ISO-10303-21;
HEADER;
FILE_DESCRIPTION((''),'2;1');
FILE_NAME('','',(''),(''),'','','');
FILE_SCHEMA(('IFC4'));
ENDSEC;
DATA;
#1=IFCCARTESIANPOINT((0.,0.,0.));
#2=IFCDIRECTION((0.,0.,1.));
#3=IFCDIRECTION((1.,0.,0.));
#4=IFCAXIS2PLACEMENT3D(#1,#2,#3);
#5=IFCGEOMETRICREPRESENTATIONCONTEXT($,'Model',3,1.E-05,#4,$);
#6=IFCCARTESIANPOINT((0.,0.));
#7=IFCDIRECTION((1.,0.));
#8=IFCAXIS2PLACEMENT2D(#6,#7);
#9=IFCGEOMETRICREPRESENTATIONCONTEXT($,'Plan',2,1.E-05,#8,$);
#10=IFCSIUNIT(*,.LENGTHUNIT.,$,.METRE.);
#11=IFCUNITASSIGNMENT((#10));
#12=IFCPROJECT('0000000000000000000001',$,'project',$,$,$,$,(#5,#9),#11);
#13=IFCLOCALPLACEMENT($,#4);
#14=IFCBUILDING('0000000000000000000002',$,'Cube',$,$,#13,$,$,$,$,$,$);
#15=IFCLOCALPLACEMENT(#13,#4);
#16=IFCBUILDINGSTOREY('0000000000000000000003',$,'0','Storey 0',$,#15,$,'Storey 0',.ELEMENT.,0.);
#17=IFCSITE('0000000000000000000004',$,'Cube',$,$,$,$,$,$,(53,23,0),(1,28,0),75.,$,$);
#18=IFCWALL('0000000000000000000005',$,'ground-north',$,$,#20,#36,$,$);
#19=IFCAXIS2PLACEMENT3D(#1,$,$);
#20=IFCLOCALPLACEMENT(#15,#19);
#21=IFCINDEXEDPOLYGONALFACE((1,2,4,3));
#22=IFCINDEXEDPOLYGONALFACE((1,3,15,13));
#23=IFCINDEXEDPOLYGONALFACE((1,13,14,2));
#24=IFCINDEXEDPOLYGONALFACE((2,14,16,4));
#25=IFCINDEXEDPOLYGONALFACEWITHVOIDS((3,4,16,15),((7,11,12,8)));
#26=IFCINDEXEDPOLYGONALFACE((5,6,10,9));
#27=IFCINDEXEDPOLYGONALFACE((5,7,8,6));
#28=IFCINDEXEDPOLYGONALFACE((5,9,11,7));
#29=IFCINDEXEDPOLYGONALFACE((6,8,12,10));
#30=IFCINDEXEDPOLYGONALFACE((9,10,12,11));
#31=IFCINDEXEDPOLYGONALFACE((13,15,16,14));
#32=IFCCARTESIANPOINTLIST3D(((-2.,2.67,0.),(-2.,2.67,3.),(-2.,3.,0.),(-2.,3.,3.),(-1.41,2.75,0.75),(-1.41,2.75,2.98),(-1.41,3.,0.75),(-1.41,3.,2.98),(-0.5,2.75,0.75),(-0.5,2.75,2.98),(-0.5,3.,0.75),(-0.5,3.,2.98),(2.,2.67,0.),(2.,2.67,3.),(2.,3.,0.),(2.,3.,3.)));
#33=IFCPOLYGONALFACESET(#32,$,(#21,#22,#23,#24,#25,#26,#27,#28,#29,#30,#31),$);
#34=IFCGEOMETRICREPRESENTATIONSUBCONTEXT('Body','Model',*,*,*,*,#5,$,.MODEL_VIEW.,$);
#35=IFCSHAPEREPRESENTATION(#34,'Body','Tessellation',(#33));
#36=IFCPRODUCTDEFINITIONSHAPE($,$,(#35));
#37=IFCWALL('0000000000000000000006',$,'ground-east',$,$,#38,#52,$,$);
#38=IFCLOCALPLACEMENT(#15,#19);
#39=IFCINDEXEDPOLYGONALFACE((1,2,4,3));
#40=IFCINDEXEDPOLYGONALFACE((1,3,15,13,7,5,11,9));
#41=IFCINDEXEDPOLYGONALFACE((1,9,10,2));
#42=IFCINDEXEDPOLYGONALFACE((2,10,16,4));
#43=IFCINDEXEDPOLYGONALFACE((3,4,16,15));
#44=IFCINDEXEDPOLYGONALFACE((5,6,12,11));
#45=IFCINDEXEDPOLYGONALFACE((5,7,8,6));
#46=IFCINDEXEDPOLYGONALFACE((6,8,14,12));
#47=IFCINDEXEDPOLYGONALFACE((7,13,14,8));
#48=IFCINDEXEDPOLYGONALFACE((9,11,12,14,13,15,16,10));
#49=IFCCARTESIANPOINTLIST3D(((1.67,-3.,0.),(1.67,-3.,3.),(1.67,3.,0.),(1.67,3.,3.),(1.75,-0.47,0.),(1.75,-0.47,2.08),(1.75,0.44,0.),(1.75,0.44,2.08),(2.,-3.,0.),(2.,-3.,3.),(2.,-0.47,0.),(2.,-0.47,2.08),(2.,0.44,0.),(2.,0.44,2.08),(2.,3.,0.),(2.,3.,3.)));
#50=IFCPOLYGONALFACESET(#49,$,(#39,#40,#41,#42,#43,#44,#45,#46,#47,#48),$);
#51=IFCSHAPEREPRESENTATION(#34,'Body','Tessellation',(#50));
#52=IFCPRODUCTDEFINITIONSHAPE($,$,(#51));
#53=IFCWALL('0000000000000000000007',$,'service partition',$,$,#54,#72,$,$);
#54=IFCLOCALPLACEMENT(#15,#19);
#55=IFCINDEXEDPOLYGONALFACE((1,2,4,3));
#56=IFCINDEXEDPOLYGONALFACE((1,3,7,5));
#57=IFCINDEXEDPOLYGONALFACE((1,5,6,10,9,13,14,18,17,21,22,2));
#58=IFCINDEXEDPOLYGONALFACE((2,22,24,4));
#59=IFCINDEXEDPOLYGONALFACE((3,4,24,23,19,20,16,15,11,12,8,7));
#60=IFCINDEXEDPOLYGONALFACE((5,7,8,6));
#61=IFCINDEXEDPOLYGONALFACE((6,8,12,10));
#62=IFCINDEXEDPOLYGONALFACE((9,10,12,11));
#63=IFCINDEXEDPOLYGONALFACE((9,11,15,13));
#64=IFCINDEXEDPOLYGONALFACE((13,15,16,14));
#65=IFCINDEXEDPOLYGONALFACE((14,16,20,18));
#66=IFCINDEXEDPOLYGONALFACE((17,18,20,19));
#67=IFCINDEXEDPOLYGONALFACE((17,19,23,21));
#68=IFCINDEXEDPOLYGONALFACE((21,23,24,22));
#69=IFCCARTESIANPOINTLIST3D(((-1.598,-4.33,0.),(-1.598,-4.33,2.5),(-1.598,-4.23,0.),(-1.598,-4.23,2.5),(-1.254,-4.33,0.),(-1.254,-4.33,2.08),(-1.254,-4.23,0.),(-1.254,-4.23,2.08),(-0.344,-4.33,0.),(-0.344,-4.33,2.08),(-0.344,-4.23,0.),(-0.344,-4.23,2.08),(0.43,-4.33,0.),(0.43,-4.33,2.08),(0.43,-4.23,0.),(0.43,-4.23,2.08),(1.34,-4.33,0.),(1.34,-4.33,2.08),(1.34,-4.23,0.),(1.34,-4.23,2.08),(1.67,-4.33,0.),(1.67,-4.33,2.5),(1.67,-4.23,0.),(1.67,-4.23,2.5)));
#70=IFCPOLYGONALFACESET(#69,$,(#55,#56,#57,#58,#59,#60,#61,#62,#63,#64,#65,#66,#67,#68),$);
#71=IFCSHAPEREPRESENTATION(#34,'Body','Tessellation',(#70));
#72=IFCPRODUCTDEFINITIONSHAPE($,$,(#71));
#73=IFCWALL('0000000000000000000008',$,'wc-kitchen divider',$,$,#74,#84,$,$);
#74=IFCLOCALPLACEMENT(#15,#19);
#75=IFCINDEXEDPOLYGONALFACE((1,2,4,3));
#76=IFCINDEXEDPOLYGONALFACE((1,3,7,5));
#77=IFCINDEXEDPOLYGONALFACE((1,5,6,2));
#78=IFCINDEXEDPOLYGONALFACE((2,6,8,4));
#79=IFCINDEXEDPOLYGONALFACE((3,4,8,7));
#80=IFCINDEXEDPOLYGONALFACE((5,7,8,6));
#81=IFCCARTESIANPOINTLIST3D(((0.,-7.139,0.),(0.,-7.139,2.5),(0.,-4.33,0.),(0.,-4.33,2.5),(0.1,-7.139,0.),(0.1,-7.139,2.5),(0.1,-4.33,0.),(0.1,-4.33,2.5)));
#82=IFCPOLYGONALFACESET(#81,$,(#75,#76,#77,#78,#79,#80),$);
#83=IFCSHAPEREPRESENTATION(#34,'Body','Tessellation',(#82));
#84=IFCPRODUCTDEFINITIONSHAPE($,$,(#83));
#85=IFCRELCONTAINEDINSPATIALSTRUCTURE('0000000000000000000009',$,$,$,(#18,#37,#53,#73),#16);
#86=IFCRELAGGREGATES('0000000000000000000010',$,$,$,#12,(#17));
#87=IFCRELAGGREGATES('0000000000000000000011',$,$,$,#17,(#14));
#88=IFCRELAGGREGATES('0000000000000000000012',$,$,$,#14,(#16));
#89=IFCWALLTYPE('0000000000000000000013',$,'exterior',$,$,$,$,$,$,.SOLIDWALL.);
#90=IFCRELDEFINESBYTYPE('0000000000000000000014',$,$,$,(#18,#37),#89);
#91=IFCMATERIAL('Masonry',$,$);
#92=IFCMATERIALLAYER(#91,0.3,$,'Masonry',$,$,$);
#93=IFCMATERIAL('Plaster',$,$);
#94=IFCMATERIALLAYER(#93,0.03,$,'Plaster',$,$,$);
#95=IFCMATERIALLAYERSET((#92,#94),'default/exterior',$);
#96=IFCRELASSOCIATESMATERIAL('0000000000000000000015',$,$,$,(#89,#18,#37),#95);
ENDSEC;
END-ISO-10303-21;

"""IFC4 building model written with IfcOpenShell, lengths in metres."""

from ifc_helpers import new_model, si_unit, frame, origin_with_axes, origin_2d_with_axis, place, context, subcontext, project, spatial, line, indexed_curve, outline, extrude, material, layer, layer_set, layer_usage, type_object, element, save


model = new_model("IFC4")

# Units and contexts
model_context = context("Model", 3, precision=1e-05, world=origin_with_axes())
plan_context = context("Plan", 2, precision=1e-05, world=origin_2d_with_axis())
body_context = subcontext(model_context, "Body", "Model", "MODEL_VIEW")
ifc_project = project(units=[si_unit("LENGTHUNIT", "METRE")], contexts=[model_context, plan_context])

# Site, building, storey
site = spatial("IfcSite", under=ifc_project, Name="Cube", RefLatitude=(53, 23, 0), RefLongitude=(1, 28, 0), RefElevation=75.0)
building_placement = place(None, origin_with_axes())
building = spatial("IfcBuilding", under=site, at=building_placement, Name="Cube")
storey_placement = place(building_placement, origin_with_axes())
storey = spatial("IfcBuildingStorey", under=building, at=storey_placement, Name="0", Description="Storey 0", LongName="Storey 0", CompositionType="ELEMENT", Elevation=0.0)

# Shared definitions
ifc_material_1 = material(Name="Masonry")
ifc_layer_1 = layer(ifc_material_1, 0.3, Name="Masonry")
ifc_material_2 = material(Name="Plaster")
ifc_layer_2 = layer(ifc_material_2, 0.03, Name="Plaster")
ifc_layer_set_1 = layer_set([ifc_layer_1, ifc_layer_2], Name="default/exterior")
wall_type = type_object("IfcWallType", Name="exterior", PredefinedType="SOLIDWALL", material=ifc_layer_set_1)

# Wall, opening
ifc_layer_usage_1 = layer_usage(ifc_layer_set_1, "AXIS2", "POSITIVE", 0.0)
wall_1_placement = place(storey_placement, frame((2.0, 3.0, 0.0), z_axis=(0.0, 0.0, 1.0), x_axis=(-1.0, 0.0, 0.0)))
wall_1 = element("IfcWall", 1, at=wall_1_placement, inside=storey, type_object=wall_type, material=ifc_layer_usage_1, Name="ground-north", context=body_context, shape_type="SweptSolid", body=[
    extrude(outline(indexed_curve([(0.0, 0.0), (4.0, 0.0), (4.0, 0.33), (0.0, 0.33)], segments=[line(1, 2, 3, 4, 1)])), origin_with_axes(), (0.0, 0.0, 1.0), 3.0),
])
opening_1_placement = place(wall_1_placement, frame((2.5, -0.25, 0.75), z_axis=(0.0, 0.0, 1.0), x_axis=(1.0, 0.0, 0.0)))
element("IfcOpeningElement", 2, at=opening_1_placement, cuts=wall_1, PredefinedType="OPENING", context=body_context, shape_type="SweptSolid", body=[
    extrude(outline(indexed_curve([(0.0, 0.0), (0.0, 0.5), (0.91, 0.5), (0.91, 0.0), (0.0, 0.0)], self_intersect=False)), origin_with_axes(), (0.0, 0.0, 1.0), 2.23),
])

# Wall, opening
ifc_layer_usage_2 = layer_usage(ifc_layer_set_1, "AXIS2", "POSITIVE", 0.0)
wall_2_placement = place(storey_placement, frame((2.0, -3.0, 0.0), z_axis=(0.0, 0.0, 1.0), x_axis=(0.0, 1.0, 0.0)))
wall_2 = element("IfcWall", 3, at=wall_2_placement, inside=storey, type_object=wall_type, material=ifc_layer_usage_2, Name="ground-east", context=body_context, shape_type="SweptSolid", body=[
    extrude(outline(indexed_curve([(0.0, 0.0), (6.0, 0.0), (6.0, 0.33), (0.0, 0.33)], segments=[line(1, 2, 3, 4, 1)])), origin_with_axes(), (0.0, 0.0, 1.0), 3.0),
])
opening_2_placement = place(wall_2_placement, frame((2.53, -0.25, 0.0), z_axis=(0.0, 0.0, 1.0), x_axis=(1.0, 0.0, 0.0)))
element("IfcOpeningElement", 4, at=opening_2_placement, cuts=wall_2, PredefinedType="OPENING", context=body_context, shape_type="SweptSolid", body=[
    extrude(outline(indexed_curve([(0.0, 0.0), (0.0, 0.5), (0.91, 0.5), (0.91, 0.0), (0.0, 0.0)], self_intersect=False)), origin_with_axes(), (0.0, 0.0, 1.0), 2.08),
])

# Wall, openings
wall_3_placement = place(storey_placement, frame((-1.598, -4.33, 0.0), z_axis=(0.0, 0.0, 1.0), x_axis=(1.0, 0.0, 0.0)))
wall_3 = element("IfcWall", 5, at=wall_3_placement, inside=storey, Name="service partition", context=body_context, shape_type="SweptSolid", body=[
    extrude(outline(indexed_curve([(0.0, 0.0), (0.0, 0.1), (3.268, 0.1), (3.268, 0.0), (0.0, 0.0)], self_intersect=False)), origin_with_axes(), (0.0, 0.0, 1.0), 2.5),
])
opening_3_placement = place(wall_3_placement, frame((0.344, -0.05, 0.0), z_axis=(0.0, 0.0, 1.0), x_axis=(1.0, 0.0, 0.0)))
element("IfcOpeningElement", 6, at=opening_3_placement, cuts=wall_3, context=body_context, shape_type="SweptSolid", body=[
    extrude(outline(indexed_curve([(0.0, 0.0), (0.0, 0.3), (0.91, 0.3), (0.91, 0.0), (0.0, 0.0)], self_intersect=False)), origin_with_axes(), (0.0, 0.0, 1.0), 2.08),
])
opening_4_placement = place(wall_3_placement, frame((2.028, -0.05, 0.0), z_axis=(0.0, 0.0, 1.0), x_axis=(1.0, 0.0, 0.0)))
element("IfcOpeningElement", 7, at=opening_4_placement, cuts=wall_3, context=body_context, shape_type="SweptSolid", body=[
    extrude(outline(indexed_curve([(0.0, 0.0), (0.0, 0.3), (0.91, 0.3), (0.91, 0.0), (0.0, 0.0)], self_intersect=False)), origin_with_axes(), (0.0, 0.0, 1.0), 2.08),
])

# Wall
wall_4_placement = place(storey_placement, frame((0.0, -4.33, 0.0), z_axis=(0.0, 0.0, 1.0), x_axis=(0.0, -1.0, 0.0)))
element("IfcWall", 8, at=wall_4_placement, inside=storey, Name="wc-kitchen divider", context=body_context, shape_type="SweptSolid", body=[
    extrude(outline(indexed_curve([(0.0, 0.0), (0.0, 0.1), (2.809, 0.1), (2.809, 0.0), (0.0, 0.0)], self_intersect=False)), origin_with_axes(), (0.0, 0.0, 1.0), 2.5),
])

save(model, "model.ifc")
